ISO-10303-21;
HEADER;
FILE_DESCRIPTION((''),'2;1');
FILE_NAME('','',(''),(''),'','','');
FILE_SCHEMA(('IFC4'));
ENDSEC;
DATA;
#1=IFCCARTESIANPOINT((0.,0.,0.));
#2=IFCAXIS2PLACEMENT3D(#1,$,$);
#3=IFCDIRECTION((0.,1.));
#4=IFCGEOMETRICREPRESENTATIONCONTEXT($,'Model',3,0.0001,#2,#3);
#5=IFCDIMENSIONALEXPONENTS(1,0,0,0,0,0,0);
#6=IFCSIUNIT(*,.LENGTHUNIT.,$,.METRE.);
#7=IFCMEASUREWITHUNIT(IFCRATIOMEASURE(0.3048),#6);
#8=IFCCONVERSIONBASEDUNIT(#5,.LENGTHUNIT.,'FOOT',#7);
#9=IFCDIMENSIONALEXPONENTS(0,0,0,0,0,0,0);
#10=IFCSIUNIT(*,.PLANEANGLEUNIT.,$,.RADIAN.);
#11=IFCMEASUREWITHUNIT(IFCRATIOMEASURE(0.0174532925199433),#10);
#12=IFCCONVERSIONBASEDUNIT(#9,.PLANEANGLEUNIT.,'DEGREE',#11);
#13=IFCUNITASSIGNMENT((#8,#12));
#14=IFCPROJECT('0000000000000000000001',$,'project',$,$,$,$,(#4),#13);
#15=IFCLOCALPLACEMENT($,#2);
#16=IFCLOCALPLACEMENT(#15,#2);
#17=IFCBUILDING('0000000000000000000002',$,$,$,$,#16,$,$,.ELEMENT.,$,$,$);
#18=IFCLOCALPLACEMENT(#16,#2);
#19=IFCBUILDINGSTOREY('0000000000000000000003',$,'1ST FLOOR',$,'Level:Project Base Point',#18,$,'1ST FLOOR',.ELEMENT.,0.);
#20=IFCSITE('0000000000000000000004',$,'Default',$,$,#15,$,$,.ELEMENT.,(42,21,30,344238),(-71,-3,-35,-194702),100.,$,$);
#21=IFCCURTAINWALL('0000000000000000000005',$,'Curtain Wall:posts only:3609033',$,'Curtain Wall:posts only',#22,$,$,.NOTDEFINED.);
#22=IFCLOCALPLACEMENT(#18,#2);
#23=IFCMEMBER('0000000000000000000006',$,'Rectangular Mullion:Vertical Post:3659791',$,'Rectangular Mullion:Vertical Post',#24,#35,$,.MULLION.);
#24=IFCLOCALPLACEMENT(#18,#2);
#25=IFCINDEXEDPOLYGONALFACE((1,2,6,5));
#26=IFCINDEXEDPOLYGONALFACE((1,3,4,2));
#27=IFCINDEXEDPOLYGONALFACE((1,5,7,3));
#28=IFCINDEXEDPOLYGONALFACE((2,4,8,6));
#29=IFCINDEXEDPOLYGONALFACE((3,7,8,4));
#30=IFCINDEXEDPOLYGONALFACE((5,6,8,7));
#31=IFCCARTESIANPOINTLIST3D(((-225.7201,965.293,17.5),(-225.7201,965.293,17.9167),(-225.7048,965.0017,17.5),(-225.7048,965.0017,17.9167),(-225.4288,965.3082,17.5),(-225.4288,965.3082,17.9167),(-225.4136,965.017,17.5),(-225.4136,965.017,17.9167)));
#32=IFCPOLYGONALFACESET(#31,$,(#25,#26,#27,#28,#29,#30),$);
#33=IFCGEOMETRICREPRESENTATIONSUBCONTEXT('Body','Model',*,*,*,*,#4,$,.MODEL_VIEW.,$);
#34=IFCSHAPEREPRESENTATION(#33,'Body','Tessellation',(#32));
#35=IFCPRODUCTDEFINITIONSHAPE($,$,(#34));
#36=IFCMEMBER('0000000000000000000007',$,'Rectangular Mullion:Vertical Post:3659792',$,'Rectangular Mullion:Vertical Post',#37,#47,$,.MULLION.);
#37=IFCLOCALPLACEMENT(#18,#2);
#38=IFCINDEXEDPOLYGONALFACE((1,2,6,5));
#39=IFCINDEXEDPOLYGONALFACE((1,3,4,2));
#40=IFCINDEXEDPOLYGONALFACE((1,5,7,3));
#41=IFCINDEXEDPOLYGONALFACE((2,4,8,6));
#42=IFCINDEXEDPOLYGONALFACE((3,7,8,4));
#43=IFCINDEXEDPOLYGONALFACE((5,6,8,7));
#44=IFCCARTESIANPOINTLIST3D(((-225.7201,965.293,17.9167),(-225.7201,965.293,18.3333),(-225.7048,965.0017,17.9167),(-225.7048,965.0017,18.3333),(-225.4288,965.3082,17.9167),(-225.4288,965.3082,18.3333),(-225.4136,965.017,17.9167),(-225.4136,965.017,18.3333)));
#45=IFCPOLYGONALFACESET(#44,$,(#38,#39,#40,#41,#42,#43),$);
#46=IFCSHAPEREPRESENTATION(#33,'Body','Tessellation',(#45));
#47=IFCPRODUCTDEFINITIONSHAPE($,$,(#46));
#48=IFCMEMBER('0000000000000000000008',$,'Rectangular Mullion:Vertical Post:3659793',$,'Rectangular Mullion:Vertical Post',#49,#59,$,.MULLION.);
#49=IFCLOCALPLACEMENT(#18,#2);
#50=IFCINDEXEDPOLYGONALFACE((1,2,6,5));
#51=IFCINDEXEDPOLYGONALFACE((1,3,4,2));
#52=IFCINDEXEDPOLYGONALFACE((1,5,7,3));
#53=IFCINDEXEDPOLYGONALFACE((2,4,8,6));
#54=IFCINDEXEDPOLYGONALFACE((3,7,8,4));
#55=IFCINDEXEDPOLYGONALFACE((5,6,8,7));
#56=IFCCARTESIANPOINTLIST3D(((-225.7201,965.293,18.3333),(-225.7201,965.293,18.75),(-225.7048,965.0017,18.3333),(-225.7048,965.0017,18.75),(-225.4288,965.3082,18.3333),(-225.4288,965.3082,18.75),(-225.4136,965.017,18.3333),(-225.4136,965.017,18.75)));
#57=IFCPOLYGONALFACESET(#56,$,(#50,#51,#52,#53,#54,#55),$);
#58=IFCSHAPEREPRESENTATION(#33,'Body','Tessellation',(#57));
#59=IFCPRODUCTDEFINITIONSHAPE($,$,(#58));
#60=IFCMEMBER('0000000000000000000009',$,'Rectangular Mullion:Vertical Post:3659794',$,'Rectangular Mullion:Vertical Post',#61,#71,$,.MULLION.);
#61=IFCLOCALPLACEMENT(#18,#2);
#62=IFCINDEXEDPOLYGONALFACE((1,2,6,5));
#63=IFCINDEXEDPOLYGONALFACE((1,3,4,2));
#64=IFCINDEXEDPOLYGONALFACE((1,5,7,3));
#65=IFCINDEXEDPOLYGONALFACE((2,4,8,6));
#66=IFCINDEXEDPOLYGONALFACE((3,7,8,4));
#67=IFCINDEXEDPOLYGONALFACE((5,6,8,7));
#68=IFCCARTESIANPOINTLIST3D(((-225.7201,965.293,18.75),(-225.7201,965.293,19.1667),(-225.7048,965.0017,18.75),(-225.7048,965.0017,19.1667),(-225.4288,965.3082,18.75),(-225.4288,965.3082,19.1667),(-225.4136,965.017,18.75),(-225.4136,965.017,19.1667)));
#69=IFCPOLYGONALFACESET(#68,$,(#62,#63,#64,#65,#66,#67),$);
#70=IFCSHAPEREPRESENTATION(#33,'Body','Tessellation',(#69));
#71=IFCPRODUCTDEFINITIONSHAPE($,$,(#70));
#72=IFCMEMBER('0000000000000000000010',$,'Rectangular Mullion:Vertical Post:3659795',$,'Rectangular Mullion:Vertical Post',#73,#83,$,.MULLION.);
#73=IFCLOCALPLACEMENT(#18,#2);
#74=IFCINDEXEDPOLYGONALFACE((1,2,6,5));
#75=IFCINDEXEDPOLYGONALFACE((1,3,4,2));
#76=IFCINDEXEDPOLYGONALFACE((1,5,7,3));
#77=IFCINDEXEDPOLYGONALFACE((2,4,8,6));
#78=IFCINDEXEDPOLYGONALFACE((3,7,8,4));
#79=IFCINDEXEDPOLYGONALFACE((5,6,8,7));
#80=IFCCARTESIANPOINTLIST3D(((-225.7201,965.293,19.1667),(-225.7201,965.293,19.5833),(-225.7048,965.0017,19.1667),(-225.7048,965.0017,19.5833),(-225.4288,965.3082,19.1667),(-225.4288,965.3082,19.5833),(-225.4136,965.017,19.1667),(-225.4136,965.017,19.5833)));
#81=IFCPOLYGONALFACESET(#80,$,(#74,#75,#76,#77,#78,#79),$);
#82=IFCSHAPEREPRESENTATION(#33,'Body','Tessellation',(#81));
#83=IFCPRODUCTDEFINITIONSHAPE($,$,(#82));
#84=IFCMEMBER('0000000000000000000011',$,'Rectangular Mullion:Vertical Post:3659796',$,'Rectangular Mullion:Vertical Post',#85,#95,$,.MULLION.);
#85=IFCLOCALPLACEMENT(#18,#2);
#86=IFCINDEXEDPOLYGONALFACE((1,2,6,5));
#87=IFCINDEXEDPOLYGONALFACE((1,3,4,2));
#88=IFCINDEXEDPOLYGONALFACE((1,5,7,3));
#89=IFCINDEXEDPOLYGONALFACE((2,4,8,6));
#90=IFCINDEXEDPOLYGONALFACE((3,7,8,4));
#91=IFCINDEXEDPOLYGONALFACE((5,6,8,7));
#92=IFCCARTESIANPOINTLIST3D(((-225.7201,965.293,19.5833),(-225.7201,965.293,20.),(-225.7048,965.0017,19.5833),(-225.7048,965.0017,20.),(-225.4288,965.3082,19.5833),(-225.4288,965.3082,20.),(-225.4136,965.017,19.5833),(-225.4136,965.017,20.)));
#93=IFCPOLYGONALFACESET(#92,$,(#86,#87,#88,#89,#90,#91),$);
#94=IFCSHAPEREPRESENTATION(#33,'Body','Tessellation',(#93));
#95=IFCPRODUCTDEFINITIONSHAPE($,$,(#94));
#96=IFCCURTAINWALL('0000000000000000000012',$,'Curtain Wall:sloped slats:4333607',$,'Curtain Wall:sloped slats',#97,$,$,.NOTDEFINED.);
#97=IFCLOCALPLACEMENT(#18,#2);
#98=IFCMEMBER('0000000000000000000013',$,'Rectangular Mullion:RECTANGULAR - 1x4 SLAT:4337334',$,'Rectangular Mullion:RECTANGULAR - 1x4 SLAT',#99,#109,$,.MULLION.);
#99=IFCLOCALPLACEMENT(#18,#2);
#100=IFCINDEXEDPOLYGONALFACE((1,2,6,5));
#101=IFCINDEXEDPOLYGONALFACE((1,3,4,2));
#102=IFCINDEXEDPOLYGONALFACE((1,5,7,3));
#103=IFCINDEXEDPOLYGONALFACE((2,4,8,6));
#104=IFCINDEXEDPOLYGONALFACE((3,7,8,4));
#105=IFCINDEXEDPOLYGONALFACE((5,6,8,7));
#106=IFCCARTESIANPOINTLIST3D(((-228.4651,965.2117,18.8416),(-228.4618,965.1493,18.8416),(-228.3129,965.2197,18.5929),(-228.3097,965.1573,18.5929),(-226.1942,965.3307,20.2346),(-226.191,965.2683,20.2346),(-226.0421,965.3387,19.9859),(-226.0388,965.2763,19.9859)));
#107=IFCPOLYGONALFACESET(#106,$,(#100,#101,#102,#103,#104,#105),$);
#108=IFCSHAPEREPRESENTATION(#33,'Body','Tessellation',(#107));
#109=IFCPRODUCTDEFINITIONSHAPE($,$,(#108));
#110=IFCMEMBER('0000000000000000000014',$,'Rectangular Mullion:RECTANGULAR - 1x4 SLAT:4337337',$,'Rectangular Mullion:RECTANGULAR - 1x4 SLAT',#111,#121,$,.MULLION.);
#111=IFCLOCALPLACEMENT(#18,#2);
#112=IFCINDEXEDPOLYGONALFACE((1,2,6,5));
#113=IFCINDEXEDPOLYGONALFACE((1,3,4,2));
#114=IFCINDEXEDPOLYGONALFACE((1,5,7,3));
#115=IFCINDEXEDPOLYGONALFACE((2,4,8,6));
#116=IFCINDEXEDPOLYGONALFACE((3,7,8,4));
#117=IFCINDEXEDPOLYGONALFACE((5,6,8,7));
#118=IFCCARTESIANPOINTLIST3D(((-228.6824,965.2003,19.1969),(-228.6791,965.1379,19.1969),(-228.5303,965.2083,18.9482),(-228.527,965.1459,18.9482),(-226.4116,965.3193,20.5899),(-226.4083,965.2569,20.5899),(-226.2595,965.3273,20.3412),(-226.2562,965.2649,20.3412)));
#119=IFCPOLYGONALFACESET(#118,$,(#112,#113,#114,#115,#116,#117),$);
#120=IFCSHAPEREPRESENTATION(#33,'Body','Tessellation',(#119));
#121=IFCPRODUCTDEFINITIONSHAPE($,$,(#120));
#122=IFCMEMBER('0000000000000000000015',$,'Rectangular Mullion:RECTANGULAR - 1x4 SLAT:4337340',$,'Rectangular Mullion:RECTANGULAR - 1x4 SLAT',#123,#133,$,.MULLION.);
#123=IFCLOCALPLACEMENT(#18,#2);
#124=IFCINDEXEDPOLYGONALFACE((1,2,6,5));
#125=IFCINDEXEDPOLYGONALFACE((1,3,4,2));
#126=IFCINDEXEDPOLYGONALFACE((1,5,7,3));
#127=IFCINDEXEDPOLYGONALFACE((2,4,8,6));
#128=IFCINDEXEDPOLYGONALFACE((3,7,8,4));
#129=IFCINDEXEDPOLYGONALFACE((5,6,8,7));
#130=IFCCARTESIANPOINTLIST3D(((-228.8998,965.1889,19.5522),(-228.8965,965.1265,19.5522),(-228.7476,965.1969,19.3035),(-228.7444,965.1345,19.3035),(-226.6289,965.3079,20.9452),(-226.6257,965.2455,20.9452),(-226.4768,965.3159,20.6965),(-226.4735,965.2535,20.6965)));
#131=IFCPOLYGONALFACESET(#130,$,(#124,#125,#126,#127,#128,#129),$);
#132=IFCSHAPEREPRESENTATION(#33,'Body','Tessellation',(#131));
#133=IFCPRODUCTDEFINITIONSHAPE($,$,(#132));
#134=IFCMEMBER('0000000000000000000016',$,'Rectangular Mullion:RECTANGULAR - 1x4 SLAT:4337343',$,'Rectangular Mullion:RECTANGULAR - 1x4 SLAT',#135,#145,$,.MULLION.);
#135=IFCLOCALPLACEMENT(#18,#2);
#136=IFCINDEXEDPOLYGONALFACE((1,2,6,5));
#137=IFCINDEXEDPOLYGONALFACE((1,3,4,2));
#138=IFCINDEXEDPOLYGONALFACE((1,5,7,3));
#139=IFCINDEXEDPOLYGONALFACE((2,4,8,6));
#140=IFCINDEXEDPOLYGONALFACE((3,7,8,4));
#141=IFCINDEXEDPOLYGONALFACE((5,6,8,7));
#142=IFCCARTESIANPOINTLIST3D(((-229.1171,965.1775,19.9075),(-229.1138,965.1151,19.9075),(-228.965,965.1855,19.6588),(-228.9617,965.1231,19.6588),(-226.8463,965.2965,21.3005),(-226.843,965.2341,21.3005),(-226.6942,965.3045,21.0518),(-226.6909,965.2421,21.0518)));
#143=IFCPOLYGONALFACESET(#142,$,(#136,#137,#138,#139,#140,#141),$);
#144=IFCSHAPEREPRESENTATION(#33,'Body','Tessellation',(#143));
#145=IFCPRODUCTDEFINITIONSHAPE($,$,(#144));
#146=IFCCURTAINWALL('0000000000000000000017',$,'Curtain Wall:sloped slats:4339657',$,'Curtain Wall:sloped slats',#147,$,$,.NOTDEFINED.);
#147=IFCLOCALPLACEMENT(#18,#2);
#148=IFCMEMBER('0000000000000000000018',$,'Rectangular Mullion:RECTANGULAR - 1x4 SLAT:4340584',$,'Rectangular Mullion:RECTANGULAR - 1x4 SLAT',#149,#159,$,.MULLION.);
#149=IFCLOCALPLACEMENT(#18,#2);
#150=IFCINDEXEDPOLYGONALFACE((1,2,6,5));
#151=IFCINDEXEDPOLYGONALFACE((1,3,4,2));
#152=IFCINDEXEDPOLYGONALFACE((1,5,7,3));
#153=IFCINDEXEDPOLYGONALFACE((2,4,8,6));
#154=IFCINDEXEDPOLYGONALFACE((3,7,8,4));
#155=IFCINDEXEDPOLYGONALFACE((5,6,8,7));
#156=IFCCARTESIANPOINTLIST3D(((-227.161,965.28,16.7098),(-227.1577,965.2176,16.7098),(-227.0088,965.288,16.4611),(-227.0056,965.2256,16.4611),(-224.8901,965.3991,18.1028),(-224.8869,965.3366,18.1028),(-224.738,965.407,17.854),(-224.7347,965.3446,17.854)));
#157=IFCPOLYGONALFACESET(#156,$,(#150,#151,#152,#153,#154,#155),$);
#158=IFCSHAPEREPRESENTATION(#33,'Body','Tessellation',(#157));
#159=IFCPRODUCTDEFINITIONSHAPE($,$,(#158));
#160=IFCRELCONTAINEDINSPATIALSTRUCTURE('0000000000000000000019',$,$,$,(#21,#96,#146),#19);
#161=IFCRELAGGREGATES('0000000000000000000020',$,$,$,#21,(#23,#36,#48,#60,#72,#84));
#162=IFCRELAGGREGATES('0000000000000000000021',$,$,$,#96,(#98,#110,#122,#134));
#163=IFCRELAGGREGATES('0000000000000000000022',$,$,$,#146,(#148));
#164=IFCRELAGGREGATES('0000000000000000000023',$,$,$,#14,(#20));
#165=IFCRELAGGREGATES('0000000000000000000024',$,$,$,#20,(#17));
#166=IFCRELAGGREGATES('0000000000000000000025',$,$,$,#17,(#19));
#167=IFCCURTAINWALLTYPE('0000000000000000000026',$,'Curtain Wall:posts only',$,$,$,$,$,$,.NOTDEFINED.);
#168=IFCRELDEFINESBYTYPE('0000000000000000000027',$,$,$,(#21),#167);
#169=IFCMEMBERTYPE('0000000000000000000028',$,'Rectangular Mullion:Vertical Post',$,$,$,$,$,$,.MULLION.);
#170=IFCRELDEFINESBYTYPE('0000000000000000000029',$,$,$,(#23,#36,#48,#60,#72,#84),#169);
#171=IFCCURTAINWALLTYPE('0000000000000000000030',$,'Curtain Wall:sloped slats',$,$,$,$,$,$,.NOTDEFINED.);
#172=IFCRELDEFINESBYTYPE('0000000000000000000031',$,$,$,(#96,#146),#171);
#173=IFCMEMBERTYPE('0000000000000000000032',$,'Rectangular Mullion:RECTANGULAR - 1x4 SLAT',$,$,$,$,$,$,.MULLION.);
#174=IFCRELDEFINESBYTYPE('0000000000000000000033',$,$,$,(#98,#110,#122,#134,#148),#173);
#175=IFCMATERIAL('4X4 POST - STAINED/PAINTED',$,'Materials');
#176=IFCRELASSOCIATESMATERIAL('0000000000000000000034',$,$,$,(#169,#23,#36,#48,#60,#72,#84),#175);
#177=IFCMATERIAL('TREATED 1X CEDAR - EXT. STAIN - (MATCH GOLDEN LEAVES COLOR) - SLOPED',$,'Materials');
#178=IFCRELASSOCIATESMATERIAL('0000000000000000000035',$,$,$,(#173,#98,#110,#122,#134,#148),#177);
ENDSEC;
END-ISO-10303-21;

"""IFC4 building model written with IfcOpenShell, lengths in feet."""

from ifc_helpers import new_model, entity, si_unit, converted_unit, direction, frame, frame_2d, origin, origin_2d_with_axis, place, context, subcontext, project, spatial, rectangle, extrude, source, transform, mapped, material, material_profile, profile_set, profile_usage, type_object, type_shapes, element, aggregate, save


model = new_model("IFC4")

# Units and contexts
model_context = context("Model", 3, precision=0.0001, world=origin(), true_north=direction((0.0, 1.0)))
body_context = subcontext(model_context, "Body", "Model", "MODEL_VIEW")
ifc_project = project(units=[converted_unit("LENGTHUNIT", "FOOT", entity("IfcRatioMeasure", 0.3048), si_unit("LENGTHUNIT", "METRE"), dimensions=[1, 0, 0, 0, 0, 0, 0]), converted_unit("PLANEANGLEUNIT", "DEGREE", entity("IfcRatioMeasure", 0.0174532925199433), si_unit("PLANEANGLEUNIT", "RADIAN"), dimensions=[0, 0, 0, 0, 0, 0, 0])], contexts=[model_context])

# Site, building, storey
site_placement = place(None, origin())
site = spatial("IfcSite", under=ifc_project, at=site_placement, Name="Default", CompositionType="ELEMENT", RefLatitude=(42, 21, 30, 344238), RefLongitude=(-71, -3, -35, -194702), RefElevation=100.0)
building_placement = place(site_placement, origin())
building = spatial("IfcBuilding", under=site, at=building_placement, CompositionType="ELEMENT")
storey_placement = place(building_placement, origin())
storey = spatial("IfcBuildingStorey", under=building, at=storey_placement, Name="1ST FLOOR", ObjectType="Level:Project Base Point", LongName="1ST FLOOR", CompositionType="ELEMENT", Elevation=0.0)

# Curtain walls, members
curtain_wall_type_1 = type_object("IfcCurtainWallType", Name="Curtain Wall:posts only", PredefinedType="NOTDEFINED")
curtain_wall_1_placement = place(storey_placement, origin())
curtain_wall_1 = element("IfcCurtainWall", 1, at=curtain_wall_1_placement, inside=storey, type_object=curtain_wall_type_1, Name="Curtain Wall:posts only:3609033", ObjectType="Curtain Wall:posts only", PredefinedType="NOTDEFINED")
ifc_material_1 = material(Name="4X4 POST - STAINED/PAINTED", Category="Materials")
ifc_material_profile_1 = material_profile(ifc_material_1, rectangle(XDim=0.2917, YDim=0.2917, at=origin_2d_with_axis()), Name="Vertical Post")
ifc_profile_set_1 = profile_set([ifc_material_profile_1], Name="Vertical Post")
member_type_1 = type_object("IfcMemberType", Name="Rectangular Mullion:Vertical Post", PredefinedType="MULLION", material=ifc_profile_set_1)
shared_shape_1 = source(origin(), body_context, "Body", "SweptSolid", [
    extrude(rectangle(XDim=0.2917, YDim=0.2917, at=origin_2d_with_axis()), frame((0.0, -0.2083, -0.4167), z_axis=(0.0, 0.0, 1.0), x_axis=(0.0, -1.0, 0.0)), (0.0, 0.0, 1.0), 0.4167),
])
type_shapes(member_type_1, [shared_shape_1])
ifc_profile_usage_1 = profile_usage(ifc_profile_set_1)
member_1_placement = place(storey_placement, frame((-225.5777, 965.363, 17.5), z_axis=(0.0, 0.0, -1.0), x_axis=(-0.99863, -0.052336, 0.0)))
member_1 = element("IfcMember", 2, at=member_1_placement, type_object=member_type_1, material=ifc_profile_usage_1, Name="Rectangular Mullion:Vertical Post:3659791", ObjectType="Rectangular Mullion:Vertical Post", PredefinedType="MULLION", context=body_context, shape_type="MappedRepresentation", body=[
    mapped(shared_shape_1, transform((0.0, 0.0, 0.0), scale=1.0)),
])
ifc_profile_usage_2 = profile_usage(ifc_profile_set_1)
member_2_placement = place(storey_placement, frame((-225.5777, 965.363, 17.9167), z_axis=(0.0, 0.0, -1.0), x_axis=(-0.99863, -0.052336, 0.0)))
member_2 = element("IfcMember", 3, at=member_2_placement, type_object=member_type_1, material=ifc_profile_usage_2, Name="Rectangular Mullion:Vertical Post:3659792", ObjectType="Rectangular Mullion:Vertical Post", PredefinedType="MULLION", context=body_context, shape_type="MappedRepresentation", body=[
    mapped(shared_shape_1, transform((0.0, 0.0, 0.0), scale=1.0)),
])
ifc_profile_usage_3 = profile_usage(ifc_profile_set_1)
member_3_placement = place(storey_placement, frame((-225.5777, 965.363, 18.3333), z_axis=(0.0, 0.0, -1.0), x_axis=(-0.99863, -0.052336, 0.0)))
member_3 = element("IfcMember", 4, at=member_3_placement, type_object=member_type_1, material=ifc_profile_usage_3, Name="Rectangular Mullion:Vertical Post:3659793", ObjectType="Rectangular Mullion:Vertical Post", PredefinedType="MULLION", context=body_context, shape_type="MappedRepresentation", body=[
    mapped(shared_shape_1, transform((0.0, 0.0, 0.0), scale=1.0)),
])
ifc_profile_usage_4 = profile_usage(ifc_profile_set_1)
member_4_placement = place(storey_placement, frame((-225.5777, 965.363, 18.75), z_axis=(0.0, 0.0, -1.0), x_axis=(-0.99863, -0.052336, 0.0)))
member_4 = element("IfcMember", 5, at=member_4_placement, type_object=member_type_1, material=ifc_profile_usage_4, Name="Rectangular Mullion:Vertical Post:3659794", ObjectType="Rectangular Mullion:Vertical Post", PredefinedType="MULLION", context=body_context, shape_type="MappedRepresentation", body=[
    mapped(shared_shape_1, transform((0.0, 0.0, 0.0), scale=1.0)),
])
ifc_profile_usage_5 = profile_usage(ifc_profile_set_1)
member_5_placement = place(storey_placement, frame((-225.5777, 965.363, 19.1667), z_axis=(0.0, 0.0, -1.0), x_axis=(-0.99863, -0.052336, 0.0)))
member_5 = element("IfcMember", 6, at=member_5_placement, type_object=member_type_1, material=ifc_profile_usage_5, Name="Rectangular Mullion:Vertical Post:3659795", ObjectType="Rectangular Mullion:Vertical Post", PredefinedType="MULLION", context=body_context, shape_type="MappedRepresentation", body=[
    mapped(shared_shape_1, transform((0.0, 0.0, 0.0), scale=1.0)),
])
ifc_profile_usage_6 = profile_usage(ifc_profile_set_1)
member_6_placement = place(storey_placement, frame((-225.5777, 965.363, 19.5833), z_axis=(0.0, 0.0, -1.0), x_axis=(-0.99863, -0.052336, 0.0)))
member_6 = element("IfcMember", 7, at=member_6_placement, type_object=member_type_1, material=ifc_profile_usage_6, Name="Rectangular Mullion:Vertical Post:3659796", ObjectType="Rectangular Mullion:Vertical Post", PredefinedType="MULLION", context=body_context, shape_type="MappedRepresentation", body=[
    mapped(shared_shape_1, transform((0.0, 0.0, 0.0), scale=1.0)),
])
aggregate(curtain_wall_1, [member_1, member_2, member_3, member_4, member_5, member_6])
curtain_wall_type_2 = type_object("IfcCurtainWallType", Name="Curtain Wall:sloped slats", PredefinedType="NOTDEFINED")
curtain_wall_2_placement = place(storey_placement, origin())
curtain_wall_2 = element("IfcCurtainWall", 8, at=curtain_wall_2_placement, inside=storey, type_object=curtain_wall_type_2, Name="Curtain Wall:sloped slats:4333607", ObjectType="Curtain Wall:sloped slats", PredefinedType="NOTDEFINED")
ifc_material_2 = material(Name="TREATED 1X CEDAR - EXT. STAIN - (MATCH GOLDEN LEAVES COLOR) - SLOPED", Category="Materials")
ifc_material_profile_2 = material_profile(ifc_material_2, rectangle(XDim=0.0625, YDim=0.2917, at=frame_2d((0.0, 0.0), x_axis=(1.0, 0.0))), Name="RECTANGULAR - 1x4 SLAT")
ifc_profile_set_2 = profile_set([ifc_material_profile_2], Name="RECTANGULAR - 1x4 SLAT")
ifc_profile_usage_7 = profile_usage(ifc_profile_set_2)
member_type_2 = type_object("IfcMemberType", Name="Rectangular Mullion:RECTANGULAR - 1x4 SLAT", PredefinedType="MULLION", material=ifc_profile_set_2)
shared_shape_2 = source(origin(), body_context, "Body", "SweptSolid", [
    extrude(rectangle(XDim=0.0625, YDim=0.2917, at=frame_2d((0.0, 0.0), x_axis=(1.0, 0.0))), frame((0.0, 0.0, -2.6667), z_axis=(0.0, 0.0, 1.0), x_axis=(0.0, -1.0, 0.0)), (0.0, 0.0, 1.0), 2.6667),
])
type_shapes(member_type_2, [shared_shape_2])
member_7_placement = place(storey_placement, frame((-228.3874, 965.1845, 18.7173), z_axis=(-0.851559, -0.044628, -0.522356), x_axis=(-0.52164, -0.027338, 0.852727)))
member_7 = element("IfcMember", 9, at=member_7_placement, type_object=member_type_2, material=ifc_profile_usage_7, Name="Rectangular Mullion:RECTANGULAR - 1x4 SLAT:4337334", ObjectType="Rectangular Mullion:RECTANGULAR - 1x4 SLAT", PredefinedType="MULLION", context=body_context, shape_type="MappedRepresentation", body=[
    mapped(shared_shape_2, transform((0.0, 0.0, 0.0), scale=1.0)),
])
ifc_profile_usage_8 = profile_usage(ifc_profile_set_2)
member_8_placement = place(storey_placement, frame((-228.6047, 965.1731, 19.0726), z_axis=(-0.851559, -0.044628, -0.522356), x_axis=(-0.52164, -0.027338, 0.852727)))
member_8 = element("IfcMember", 10, at=member_8_placement, type_object=member_type_2, material=ifc_profile_usage_8, Name="Rectangular Mullion:RECTANGULAR - 1x4 SLAT:4337337", ObjectType="Rectangular Mullion:RECTANGULAR - 1x4 SLAT", PredefinedType="MULLION", context=body_context, shape_type="MappedRepresentation", body=[
    mapped(shared_shape_2, transform((0.0, 0.0, 0.0), scale=1.0)),
])
ifc_profile_usage_9 = profile_usage(ifc_profile_set_2)
member_9_placement = place(storey_placement, frame((-228.8221, 965.1617, 19.4279), z_axis=(-0.851559, -0.044628, -0.522356), x_axis=(-0.52164, -0.027338, 0.852727)))
member_9 = element("IfcMember", 11, at=member_9_placement, type_object=member_type_2, material=ifc_profile_usage_9, Name="Rectangular Mullion:RECTANGULAR - 1x4 SLAT:4337340", ObjectType="Rectangular Mullion:RECTANGULAR - 1x4 SLAT", PredefinedType="MULLION", context=body_context, shape_type="MappedRepresentation", body=[
    mapped(shared_shape_2, transform((0.0, 0.0, 0.0), scale=1.0)),
])
ifc_profile_usage_10 = profile_usage(ifc_profile_set_2)
member_10_placement = place(storey_placement, frame((-229.0394, 965.1503, 19.7832), z_axis=(-0.851559, -0.044628, -0.522356), x_axis=(-0.52164, -0.027338, 0.852727)))
member_10 = element("IfcMember", 12, at=member_10_placement, type_object=member_type_2, material=ifc_profile_usage_10, Name="Rectangular Mullion:RECTANGULAR - 1x4 SLAT:4337343", ObjectType="Rectangular Mullion:RECTANGULAR - 1x4 SLAT", PredefinedType="MULLION", context=body_context, shape_type="MappedRepresentation", body=[
    mapped(shared_shape_2, transform((0.0, 0.0, 0.0), scale=1.0)),
])
aggregate(curtain_wall_2, [member_7, member_8, member_9, member_10])

# Curtain wall, member
curtain_wall_3_placement = place(storey_placement, origin())
curtain_wall_3 = element("IfcCurtainWall", 13, at=curtain_wall_3_placement, inside=storey, type_object=curtain_wall_type_2, Name="Curtain Wall:sloped slats:4339657", ObjectType="Curtain Wall:sloped slats", PredefinedType="NOTDEFINED")
ifc_profile_usage_11 = profile_usage(ifc_profile_set_2)
member_11_placement = place(storey_placement, frame((-227.0833, 965.2528, 16.5854), z_axis=(-0.851559, -0.044628, -0.522356), x_axis=(-0.52164, -0.027338, 0.852727)))
member_11 = element("IfcMember", 14, at=member_11_placement, type_object=member_type_2, material=ifc_profile_usage_11, Name="Rectangular Mullion:RECTANGULAR - 1x4 SLAT:4340584", ObjectType="Rectangular Mullion:RECTANGULAR - 1x4 SLAT", PredefinedType="MULLION", context=body_context, shape_type="MappedRepresentation", body=[
    mapped(shared_shape_2, transform((0.0, 0.0, 0.0), scale=1.0)),
])
aggregate(curtain_wall_3, [member_11])

save(model, "model.ifc")
